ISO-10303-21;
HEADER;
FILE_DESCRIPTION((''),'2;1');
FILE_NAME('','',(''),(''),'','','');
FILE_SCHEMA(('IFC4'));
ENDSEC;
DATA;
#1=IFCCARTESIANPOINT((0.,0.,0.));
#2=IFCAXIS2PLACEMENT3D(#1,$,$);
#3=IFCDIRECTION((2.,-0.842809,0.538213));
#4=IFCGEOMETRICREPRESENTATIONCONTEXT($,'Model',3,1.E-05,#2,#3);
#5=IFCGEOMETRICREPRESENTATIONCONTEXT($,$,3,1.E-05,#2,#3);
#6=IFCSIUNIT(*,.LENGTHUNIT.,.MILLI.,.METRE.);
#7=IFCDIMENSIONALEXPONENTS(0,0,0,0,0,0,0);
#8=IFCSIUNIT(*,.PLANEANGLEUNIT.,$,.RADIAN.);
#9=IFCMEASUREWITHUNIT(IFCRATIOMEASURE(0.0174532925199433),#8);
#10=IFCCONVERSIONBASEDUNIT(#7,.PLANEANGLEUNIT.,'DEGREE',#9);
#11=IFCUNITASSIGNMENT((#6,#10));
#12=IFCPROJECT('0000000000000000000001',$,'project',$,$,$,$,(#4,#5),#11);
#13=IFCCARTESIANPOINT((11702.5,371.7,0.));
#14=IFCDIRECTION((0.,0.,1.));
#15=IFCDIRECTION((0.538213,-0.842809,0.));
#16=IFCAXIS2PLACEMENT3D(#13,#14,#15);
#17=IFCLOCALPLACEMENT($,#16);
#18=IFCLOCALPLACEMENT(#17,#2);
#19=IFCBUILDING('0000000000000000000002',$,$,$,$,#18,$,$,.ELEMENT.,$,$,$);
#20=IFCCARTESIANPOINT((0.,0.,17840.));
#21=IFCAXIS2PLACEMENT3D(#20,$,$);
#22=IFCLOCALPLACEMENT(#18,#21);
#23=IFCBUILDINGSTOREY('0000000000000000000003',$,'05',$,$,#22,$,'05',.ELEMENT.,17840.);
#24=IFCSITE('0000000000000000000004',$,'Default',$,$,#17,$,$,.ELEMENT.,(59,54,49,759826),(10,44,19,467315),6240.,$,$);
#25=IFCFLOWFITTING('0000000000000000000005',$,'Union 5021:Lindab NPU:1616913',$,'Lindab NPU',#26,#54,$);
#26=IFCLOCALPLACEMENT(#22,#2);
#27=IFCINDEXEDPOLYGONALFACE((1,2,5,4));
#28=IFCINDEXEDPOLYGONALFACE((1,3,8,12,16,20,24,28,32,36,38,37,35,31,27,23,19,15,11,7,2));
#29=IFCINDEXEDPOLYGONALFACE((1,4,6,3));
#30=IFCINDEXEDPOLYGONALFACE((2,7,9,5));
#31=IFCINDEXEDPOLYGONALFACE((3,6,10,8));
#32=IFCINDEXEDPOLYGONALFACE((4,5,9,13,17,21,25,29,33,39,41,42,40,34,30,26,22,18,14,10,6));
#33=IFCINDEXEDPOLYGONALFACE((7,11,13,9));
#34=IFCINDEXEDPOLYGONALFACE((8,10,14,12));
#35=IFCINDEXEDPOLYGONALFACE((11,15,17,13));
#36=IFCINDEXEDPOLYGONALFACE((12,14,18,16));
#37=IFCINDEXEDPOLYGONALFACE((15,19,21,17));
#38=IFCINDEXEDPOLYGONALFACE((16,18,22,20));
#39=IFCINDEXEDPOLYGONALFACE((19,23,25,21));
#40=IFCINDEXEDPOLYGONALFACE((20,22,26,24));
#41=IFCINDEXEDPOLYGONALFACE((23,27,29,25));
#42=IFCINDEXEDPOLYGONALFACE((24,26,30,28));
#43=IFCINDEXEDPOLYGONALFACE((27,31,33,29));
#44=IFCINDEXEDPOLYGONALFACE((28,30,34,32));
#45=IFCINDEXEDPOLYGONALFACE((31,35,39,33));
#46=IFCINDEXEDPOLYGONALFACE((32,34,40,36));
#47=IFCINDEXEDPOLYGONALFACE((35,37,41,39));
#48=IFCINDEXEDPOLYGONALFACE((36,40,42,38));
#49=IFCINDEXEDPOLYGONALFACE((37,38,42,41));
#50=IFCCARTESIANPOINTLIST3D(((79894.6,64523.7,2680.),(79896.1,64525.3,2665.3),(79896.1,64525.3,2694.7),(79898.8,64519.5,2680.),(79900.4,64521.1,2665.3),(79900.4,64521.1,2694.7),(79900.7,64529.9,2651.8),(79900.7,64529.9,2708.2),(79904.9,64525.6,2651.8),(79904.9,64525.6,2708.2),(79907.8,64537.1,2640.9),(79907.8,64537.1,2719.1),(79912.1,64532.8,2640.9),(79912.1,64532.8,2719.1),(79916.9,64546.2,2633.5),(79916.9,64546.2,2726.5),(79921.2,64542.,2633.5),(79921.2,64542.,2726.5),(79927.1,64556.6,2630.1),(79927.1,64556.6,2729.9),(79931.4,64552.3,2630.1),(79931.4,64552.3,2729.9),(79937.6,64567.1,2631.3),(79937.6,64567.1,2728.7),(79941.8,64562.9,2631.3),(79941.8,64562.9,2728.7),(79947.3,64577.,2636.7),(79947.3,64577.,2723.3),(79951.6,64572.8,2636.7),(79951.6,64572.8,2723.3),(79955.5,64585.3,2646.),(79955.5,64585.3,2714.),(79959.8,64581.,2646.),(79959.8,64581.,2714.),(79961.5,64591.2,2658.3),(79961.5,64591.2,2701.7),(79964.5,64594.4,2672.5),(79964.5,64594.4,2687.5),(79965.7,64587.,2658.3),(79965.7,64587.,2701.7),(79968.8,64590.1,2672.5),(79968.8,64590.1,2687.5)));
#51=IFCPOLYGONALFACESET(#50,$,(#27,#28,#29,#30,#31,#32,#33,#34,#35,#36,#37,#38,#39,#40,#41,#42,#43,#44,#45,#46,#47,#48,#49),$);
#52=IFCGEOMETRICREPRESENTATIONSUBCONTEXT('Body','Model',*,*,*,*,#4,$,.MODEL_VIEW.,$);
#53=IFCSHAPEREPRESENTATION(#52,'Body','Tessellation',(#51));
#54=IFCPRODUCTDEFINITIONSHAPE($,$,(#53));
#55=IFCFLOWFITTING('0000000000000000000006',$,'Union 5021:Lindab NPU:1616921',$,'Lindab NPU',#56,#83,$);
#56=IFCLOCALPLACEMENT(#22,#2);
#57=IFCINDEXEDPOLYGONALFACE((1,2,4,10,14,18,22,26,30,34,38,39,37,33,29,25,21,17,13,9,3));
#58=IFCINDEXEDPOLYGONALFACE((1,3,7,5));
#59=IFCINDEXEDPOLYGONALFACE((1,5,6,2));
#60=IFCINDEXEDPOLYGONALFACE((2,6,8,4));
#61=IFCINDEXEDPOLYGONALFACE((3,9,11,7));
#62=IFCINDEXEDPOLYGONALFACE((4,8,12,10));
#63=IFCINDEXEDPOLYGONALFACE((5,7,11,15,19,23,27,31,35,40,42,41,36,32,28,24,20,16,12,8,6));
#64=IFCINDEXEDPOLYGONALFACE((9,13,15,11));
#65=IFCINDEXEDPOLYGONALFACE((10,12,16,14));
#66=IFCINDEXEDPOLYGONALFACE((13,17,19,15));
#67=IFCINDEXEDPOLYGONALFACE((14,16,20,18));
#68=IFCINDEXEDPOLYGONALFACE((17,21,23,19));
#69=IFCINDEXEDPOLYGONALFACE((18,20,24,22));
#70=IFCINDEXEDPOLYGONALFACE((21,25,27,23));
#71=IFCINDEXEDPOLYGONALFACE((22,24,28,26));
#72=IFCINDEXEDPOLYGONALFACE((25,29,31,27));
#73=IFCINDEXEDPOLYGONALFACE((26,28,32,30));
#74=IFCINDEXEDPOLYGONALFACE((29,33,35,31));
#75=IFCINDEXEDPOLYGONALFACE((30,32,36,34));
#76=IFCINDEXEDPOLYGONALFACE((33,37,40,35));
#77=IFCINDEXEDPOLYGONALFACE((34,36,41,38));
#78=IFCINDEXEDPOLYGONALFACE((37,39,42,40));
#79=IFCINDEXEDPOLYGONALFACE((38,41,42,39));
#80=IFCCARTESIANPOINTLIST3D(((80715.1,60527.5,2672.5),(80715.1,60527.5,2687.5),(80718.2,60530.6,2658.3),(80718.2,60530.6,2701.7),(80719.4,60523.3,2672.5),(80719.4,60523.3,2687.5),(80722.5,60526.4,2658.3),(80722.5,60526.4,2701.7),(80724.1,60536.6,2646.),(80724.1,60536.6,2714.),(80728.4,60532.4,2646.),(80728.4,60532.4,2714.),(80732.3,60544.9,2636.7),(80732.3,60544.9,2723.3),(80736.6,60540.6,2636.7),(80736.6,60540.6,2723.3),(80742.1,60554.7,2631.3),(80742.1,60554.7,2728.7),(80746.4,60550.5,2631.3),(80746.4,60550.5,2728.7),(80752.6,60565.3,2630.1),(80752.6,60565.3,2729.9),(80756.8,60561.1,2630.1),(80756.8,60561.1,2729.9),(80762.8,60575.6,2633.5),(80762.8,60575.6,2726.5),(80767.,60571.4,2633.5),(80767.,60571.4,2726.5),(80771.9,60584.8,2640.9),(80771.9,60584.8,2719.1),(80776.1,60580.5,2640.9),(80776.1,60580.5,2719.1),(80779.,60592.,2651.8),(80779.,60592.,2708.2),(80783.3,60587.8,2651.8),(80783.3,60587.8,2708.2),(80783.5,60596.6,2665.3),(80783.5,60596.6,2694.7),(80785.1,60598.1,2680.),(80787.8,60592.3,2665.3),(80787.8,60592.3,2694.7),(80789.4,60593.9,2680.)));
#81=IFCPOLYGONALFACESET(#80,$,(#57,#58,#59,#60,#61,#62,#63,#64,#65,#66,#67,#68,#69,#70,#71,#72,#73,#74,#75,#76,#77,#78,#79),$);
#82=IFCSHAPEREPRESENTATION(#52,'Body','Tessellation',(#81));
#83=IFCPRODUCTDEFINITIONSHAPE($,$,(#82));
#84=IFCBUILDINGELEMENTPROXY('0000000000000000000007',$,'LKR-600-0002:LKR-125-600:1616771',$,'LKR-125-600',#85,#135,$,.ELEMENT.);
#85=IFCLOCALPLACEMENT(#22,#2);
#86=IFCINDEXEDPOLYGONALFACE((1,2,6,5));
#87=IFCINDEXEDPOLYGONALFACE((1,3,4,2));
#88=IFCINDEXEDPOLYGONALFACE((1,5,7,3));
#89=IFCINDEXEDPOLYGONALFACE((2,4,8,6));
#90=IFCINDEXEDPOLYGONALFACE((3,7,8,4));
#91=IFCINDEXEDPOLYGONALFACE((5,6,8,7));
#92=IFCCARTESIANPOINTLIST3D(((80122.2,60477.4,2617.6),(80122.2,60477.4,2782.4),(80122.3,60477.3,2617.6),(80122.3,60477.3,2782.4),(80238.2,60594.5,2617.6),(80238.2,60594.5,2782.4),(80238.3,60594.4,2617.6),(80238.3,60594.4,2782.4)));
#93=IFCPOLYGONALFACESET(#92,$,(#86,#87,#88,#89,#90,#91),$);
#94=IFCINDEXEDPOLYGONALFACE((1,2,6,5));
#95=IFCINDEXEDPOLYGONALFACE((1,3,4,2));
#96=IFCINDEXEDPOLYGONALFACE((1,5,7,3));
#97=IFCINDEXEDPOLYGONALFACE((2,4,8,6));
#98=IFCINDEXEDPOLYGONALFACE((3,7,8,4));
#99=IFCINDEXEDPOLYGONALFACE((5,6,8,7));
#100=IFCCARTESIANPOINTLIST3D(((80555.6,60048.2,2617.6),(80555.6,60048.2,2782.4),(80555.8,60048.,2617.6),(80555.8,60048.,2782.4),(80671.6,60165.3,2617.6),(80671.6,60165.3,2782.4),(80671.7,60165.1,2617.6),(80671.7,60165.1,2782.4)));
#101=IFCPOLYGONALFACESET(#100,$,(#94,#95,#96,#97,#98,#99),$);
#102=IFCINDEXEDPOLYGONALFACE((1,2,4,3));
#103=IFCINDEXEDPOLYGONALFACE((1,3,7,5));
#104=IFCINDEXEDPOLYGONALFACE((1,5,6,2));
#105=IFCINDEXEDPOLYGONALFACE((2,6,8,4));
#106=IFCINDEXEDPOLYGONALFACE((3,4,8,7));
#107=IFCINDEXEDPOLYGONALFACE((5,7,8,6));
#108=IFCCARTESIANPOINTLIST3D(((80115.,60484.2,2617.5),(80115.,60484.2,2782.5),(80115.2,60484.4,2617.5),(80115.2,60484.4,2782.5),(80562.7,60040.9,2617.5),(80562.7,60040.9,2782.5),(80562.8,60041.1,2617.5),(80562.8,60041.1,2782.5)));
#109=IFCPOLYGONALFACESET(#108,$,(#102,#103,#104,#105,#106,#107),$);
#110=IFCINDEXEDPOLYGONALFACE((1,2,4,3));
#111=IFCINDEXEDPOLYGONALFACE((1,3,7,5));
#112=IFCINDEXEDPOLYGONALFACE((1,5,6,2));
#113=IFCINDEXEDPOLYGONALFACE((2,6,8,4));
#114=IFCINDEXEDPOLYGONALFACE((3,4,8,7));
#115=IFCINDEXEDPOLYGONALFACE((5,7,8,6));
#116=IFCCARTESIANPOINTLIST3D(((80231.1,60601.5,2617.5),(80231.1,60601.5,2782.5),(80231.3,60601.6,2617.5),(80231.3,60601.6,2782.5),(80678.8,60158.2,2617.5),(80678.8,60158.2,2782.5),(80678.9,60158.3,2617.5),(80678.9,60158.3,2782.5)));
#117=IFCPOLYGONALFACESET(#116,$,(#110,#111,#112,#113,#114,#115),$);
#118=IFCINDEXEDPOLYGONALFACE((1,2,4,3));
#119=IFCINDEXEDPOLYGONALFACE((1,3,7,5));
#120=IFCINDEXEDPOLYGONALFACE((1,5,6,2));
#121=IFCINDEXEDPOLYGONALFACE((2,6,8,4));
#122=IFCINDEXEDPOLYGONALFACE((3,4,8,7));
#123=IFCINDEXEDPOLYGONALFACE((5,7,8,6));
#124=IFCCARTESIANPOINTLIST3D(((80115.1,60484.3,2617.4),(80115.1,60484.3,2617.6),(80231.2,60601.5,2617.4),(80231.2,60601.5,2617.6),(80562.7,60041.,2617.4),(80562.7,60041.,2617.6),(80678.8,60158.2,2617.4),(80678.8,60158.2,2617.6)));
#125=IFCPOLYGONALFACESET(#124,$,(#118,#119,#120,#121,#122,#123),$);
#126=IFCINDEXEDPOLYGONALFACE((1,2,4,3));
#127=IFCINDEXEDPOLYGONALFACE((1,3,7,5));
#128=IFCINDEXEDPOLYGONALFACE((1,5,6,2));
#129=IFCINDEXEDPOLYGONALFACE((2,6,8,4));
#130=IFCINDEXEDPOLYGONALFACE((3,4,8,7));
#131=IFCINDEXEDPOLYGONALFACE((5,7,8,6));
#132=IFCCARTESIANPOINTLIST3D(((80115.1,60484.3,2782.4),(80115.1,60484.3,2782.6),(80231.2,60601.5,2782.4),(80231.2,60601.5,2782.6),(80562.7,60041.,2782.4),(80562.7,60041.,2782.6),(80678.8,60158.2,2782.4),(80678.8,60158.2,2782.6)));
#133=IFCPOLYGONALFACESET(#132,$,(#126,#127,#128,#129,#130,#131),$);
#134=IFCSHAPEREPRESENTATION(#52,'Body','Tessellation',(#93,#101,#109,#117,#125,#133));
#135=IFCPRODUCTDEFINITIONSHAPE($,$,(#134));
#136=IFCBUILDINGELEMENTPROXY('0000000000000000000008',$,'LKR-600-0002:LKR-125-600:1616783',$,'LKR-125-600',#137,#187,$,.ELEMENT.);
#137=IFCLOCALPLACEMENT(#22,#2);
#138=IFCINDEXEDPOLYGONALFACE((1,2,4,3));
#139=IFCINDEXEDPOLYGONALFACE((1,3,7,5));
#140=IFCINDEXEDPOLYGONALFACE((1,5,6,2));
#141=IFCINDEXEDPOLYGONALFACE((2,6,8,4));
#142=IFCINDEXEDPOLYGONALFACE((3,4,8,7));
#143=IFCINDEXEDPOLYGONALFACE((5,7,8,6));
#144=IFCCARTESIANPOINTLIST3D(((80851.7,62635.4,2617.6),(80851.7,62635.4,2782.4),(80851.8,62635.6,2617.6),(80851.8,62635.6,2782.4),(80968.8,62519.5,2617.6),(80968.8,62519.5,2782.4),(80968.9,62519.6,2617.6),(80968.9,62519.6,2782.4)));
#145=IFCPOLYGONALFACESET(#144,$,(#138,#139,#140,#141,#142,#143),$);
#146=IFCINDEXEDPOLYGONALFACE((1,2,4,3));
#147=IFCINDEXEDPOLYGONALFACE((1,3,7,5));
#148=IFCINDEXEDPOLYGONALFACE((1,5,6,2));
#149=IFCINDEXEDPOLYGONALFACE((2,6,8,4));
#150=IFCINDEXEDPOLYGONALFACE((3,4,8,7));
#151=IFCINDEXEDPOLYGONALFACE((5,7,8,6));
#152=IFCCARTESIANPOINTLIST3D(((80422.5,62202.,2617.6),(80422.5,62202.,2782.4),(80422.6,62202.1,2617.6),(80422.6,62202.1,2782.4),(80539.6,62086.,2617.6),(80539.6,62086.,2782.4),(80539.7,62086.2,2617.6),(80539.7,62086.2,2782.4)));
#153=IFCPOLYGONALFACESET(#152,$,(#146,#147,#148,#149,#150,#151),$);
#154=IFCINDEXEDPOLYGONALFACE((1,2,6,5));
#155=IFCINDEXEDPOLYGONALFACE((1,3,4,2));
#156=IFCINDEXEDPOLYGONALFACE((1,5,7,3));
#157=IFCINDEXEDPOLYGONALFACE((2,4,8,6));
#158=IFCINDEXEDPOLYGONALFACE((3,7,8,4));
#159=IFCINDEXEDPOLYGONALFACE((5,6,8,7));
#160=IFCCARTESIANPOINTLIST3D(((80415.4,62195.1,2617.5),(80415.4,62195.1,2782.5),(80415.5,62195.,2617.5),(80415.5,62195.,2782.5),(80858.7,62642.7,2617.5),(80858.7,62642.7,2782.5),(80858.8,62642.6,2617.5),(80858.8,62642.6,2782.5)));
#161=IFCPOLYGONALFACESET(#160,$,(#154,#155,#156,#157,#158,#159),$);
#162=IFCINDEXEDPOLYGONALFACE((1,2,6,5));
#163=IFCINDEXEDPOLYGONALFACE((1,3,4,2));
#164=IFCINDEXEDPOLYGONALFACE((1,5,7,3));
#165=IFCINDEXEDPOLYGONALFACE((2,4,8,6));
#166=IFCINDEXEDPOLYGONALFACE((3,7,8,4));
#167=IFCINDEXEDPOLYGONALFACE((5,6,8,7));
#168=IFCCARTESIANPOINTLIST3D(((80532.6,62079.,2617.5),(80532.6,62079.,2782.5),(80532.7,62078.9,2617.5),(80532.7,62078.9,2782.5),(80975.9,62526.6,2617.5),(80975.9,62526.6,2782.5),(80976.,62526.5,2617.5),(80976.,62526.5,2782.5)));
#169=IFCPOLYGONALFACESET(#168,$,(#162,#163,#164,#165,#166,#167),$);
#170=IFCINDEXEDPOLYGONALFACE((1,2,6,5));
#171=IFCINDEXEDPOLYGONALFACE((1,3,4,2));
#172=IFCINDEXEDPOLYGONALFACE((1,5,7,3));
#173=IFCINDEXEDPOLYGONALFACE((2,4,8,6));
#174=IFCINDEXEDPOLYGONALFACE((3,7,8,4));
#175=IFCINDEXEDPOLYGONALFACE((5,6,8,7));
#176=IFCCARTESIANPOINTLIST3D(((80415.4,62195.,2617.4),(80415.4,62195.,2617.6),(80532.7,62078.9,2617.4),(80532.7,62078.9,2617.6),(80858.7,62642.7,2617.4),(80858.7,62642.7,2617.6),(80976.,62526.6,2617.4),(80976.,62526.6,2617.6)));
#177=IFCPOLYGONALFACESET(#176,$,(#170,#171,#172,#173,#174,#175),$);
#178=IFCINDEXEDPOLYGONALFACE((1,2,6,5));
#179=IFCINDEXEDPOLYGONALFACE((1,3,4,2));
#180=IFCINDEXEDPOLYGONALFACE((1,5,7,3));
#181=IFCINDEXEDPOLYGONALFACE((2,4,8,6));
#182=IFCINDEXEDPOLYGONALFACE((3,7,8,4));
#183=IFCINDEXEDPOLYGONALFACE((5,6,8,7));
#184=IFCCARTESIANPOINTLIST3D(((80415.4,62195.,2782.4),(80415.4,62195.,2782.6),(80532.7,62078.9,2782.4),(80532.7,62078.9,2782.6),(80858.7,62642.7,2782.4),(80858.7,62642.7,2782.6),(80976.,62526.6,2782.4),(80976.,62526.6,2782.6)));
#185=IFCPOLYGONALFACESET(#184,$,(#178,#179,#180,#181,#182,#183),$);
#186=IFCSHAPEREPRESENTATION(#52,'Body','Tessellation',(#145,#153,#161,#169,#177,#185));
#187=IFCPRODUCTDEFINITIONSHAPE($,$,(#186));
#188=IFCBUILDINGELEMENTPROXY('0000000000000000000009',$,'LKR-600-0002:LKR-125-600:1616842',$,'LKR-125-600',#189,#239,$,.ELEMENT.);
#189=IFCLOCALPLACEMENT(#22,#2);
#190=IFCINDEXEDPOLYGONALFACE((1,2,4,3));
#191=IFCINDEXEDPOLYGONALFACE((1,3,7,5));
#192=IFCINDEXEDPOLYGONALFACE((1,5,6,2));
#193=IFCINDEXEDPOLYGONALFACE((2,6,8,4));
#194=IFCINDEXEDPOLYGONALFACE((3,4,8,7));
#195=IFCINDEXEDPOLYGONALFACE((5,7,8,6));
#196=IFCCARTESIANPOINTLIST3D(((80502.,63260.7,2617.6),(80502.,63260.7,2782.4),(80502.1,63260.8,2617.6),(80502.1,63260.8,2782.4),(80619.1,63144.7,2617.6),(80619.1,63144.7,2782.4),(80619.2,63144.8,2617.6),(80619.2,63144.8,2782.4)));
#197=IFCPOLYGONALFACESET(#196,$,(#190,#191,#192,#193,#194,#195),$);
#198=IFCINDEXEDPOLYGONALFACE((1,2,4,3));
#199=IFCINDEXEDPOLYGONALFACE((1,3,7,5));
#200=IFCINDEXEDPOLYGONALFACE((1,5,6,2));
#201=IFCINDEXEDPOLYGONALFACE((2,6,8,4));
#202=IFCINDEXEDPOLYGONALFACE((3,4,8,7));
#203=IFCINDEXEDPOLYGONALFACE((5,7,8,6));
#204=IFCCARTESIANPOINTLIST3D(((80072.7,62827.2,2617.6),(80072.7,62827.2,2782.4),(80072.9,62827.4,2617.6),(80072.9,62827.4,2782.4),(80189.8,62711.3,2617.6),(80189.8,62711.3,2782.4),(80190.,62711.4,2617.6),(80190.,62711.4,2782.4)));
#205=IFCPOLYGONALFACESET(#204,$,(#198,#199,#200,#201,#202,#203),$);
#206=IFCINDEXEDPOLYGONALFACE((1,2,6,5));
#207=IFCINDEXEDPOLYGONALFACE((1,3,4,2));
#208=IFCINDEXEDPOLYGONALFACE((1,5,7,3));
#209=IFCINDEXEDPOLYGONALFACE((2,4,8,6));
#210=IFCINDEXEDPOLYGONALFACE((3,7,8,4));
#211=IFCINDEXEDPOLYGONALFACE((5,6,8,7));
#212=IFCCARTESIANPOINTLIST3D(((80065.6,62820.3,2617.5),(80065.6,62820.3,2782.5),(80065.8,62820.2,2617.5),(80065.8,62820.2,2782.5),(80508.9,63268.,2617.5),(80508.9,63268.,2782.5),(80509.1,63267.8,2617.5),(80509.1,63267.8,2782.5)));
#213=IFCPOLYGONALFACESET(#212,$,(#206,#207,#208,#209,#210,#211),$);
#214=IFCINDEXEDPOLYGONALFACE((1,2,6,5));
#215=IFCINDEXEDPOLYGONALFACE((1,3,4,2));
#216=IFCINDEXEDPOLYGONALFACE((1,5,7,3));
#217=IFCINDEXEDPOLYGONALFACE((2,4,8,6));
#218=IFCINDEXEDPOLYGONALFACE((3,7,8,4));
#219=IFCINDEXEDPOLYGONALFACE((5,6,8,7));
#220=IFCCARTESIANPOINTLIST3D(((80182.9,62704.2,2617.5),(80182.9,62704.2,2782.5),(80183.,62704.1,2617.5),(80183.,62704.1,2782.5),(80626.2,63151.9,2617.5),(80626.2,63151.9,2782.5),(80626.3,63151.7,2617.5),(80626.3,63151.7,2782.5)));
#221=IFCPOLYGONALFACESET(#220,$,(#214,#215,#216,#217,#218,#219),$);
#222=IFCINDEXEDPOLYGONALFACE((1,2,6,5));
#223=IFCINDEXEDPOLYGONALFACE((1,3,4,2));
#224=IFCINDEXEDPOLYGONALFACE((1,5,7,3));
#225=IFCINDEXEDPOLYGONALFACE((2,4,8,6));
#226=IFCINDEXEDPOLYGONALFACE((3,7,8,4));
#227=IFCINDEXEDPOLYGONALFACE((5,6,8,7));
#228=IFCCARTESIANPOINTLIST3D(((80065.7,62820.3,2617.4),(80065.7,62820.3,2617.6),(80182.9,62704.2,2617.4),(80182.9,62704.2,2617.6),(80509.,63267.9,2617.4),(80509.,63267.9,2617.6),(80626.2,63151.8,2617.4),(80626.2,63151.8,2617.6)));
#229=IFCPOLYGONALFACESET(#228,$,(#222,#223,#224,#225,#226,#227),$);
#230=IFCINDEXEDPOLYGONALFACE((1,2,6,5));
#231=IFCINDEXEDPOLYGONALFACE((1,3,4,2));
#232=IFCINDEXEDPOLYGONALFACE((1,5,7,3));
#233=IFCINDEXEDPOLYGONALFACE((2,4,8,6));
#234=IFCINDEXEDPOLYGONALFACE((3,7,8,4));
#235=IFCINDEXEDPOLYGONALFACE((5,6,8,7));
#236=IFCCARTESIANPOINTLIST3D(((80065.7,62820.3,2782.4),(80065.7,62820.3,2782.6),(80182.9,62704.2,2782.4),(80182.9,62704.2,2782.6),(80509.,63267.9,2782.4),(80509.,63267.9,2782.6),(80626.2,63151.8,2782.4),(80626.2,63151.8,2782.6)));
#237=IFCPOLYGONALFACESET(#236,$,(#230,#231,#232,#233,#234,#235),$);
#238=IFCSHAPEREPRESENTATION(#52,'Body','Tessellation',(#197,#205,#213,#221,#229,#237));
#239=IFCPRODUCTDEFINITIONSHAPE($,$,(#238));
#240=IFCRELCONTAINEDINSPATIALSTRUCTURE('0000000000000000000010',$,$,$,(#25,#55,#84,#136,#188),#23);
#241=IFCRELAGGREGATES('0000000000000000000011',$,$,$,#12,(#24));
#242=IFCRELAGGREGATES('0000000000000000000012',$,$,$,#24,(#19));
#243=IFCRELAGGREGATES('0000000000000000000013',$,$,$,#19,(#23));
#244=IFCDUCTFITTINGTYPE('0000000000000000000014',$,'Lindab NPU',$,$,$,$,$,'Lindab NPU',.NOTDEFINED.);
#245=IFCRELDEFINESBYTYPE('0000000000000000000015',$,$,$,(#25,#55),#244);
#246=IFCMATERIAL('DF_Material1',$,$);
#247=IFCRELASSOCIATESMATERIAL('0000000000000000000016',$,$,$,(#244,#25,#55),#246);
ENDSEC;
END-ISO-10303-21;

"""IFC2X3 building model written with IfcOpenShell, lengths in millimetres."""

from ifc_helpers import new_model, entity, si_unit, converted_unit, direction, frame, frame_2d, origin, place, context, subcontext, project, spatial, rectangle, circle, extrude, source, transform, mapped, material, type_object, type_shapes, element, save


model = new_model("IFC2X3")

# Units and contexts
model_context = context("Model", 3, precision=1e-05, world=origin(), true_north=direction((2.0, -0.842809, 0.538213)))
context_of_model = context(None, 3, precision=1e-05, world=origin(), true_north=direction((2.0, -0.842809, 0.538213)))
body_context = subcontext(model_context, "Body", "Model", "MODEL_VIEW")
ifc_project = project(units=[si_unit("LENGTHUNIT", "METRE", prefix="MILLI"), converted_unit("PLANEANGLEUNIT", "DEGREE", entity("IfcRatioMeasure", 0.0174532925199433), si_unit("PLANEANGLEUNIT", "RADIAN"), dimensions=[0, 0, 0, 0, 0, 0, 0])], contexts=[model_context, context_of_model])

# Site, building, storey
site_placement = place(None, frame((11702.5, 371.7, 0.0), z_axis=(0.0, 0.0, 1.0), x_axis=(0.538213, -0.842809, 0.0)))
site = spatial("IfcSite", under=ifc_project, at=site_placement, Name="Default", CompositionType="ELEMENT", RefLatitude=(59, 54, 49, 759826), RefLongitude=(10, 44, 19, 467315), RefElevation=6240.0)
building_placement = place(site_placement, origin())
building = spatial("IfcBuilding", under=site, at=building_placement, CompositionType="ELEMENT")
storey_placement = place(building_placement, frame((0.0, 0.0, 17840.0)))
storey = spatial("IfcBuildingStorey", under=building, at=storey_placement, Name="05", LongName="05", CompositionType="ELEMENT", Elevation=17840.0)

# Shared definitions
ifc_material = material(Name="DF_Material1")

# Flow fittings
duct_fitting_type_1 = type_object("IfcDuctFittingType", Name="Lindab NPU", ElementType="Lindab NPU", PredefinedType="NOTDEFINED", material=ifc_material)
shared_shape_1 = source(origin(), body_context, "Body", "SweptSolid", [
    extrude(circle(Radius=50.0, at=frame_2d((0.0, 0.0), x_axis=(1.0, 0.0))), frame((0.0, 0.0, 0.0), z_axis=(1.0, 0.0, 0.0), x_axis=(0.0, 1.0, 0.0)), (0.0, 0.0, 1.0), 6.0),
])
type_shapes(duct_fitting_type_1, [shared_shape_1])
for number, where, z_axis, x_axis, name in (
    (1, (79934.0, 64555.0, 2680.0), (0.0, 0.0, 1.0), (-0.710528, 0.703669, 0.0), "Union 5021:Lindab NPU:1616913"),
    (2, (80749.9, 60562.6, 2680.0), (0.0, 0.0, 1.0), (0.710528, -0.703669, 0.0), "Union 5021:Lindab NPU:1616921"),
):
    element("IfcFlowFitting", number, at=place(storey_placement, frame(where, z_axis=z_axis, x_axis=x_axis)), inside=storey, type_object=duct_fitting_type_1, material=ifc_material, Name=name, ObjectType="Lindab NPU", context=body_context, shape_type="MappedRepresentation", body=[
        mapped(shared_shape_1, transform((0.0, 0.0, 0.0), scale=1.0)),
    ])

# Building element proxies
shared_shape_2 = source(origin(), body_context, "Body", "SweptSolid", [
    extrude(rectangle(XDim=0.2, YDim=164.8, at=frame_2d((0.0, 0.0), x_axis=(1.0, 0.0))), frame((305.0, 0.0, -82.4)), (0.0, 0.0, 1.0), 164.8),
    extrude(rectangle(XDim=0.2, YDim=164.8, at=frame_2d((0.0, 0.0), x_axis=(1.0, 0.0))), frame((-305.0, 0.0, -82.4)), (0.0, 0.0, 1.0), 164.8),
    extrude(rectangle(XDim=0.2, YDim=630.0, at=frame_2d((0.0, 0.0), x_axis=(1.0, 0.0))), frame((0.0, 82.5, -82.5), z_axis=(0.0, 0.0, 1.0), x_axis=(0.0, 1.0, 0.0)), (0.0, 0.0, 1.0), 165.0),
    extrude(rectangle(XDim=0.2, YDim=630.0, at=frame_2d((0.0, 0.0), x_axis=(1.0, 0.0))), frame((0.0, -82.5, -82.5), z_axis=(0.0, 0.0, 1.0), x_axis=(0.0, 1.0, 0.0)), (0.0, 0.0, 1.0), 165.0),
    extrude(rectangle(XDim=165.0, YDim=630.0, at=frame_2d((0.0, 0.0), x_axis=(1.0, 0.0))), frame((0.0, 0.0, -82.6), z_axis=(0.0, 0.0, 1.0), x_axis=(0.0, -1.0, 0.0)), (0.0, 0.0, 1.0), 0.2),
    extrude(rectangle(XDim=165.0, YDim=630.0, at=frame_2d((0.0, 0.0), x_axis=(1.0, 0.0))), frame((0.0, 0.0, 82.4), z_axis=(0.0, 0.0, 1.0), x_axis=(0.0, -1.0, 0.0)), (0.0, 0.0, 1.0), 0.2),
])
for number, where, z_axis, x_axis, name in (
    (3, (80397.0, 60321.3, 2700.0), (0.0, 0.0, 1.0), (-0.710528, 0.703669, 0.0), "LKR-600-0002:LKR-125-600:1616771"),
    (4, (80695.7, 62360.8, 2700.0), (0.0, 0.0, 1.0), (0.703664, 0.710533, 0.0), "LKR-600-0002:LKR-125-600:1616783"),
    (5, (80346.0, 62986.0, 2700.0), (0.0, 0.0, 1.0), (0.703669, 0.710528, 0.0), "LKR-600-0002:LKR-125-600:1616842"),
):
    element("IfcBuildingElementProxy", number, at=place(storey_placement, frame(where, z_axis=z_axis, x_axis=x_axis)), inside=storey, Name=name, ObjectType="LKR-125-600", CompositionType="ELEMENT", context=body_context, shape_type="MappedRepresentation", body=[
        mapped(shared_shape_2, transform((0.0, 0.0, 0.0), scale=1.0)),
    ])

save(model, "model.ifc")
